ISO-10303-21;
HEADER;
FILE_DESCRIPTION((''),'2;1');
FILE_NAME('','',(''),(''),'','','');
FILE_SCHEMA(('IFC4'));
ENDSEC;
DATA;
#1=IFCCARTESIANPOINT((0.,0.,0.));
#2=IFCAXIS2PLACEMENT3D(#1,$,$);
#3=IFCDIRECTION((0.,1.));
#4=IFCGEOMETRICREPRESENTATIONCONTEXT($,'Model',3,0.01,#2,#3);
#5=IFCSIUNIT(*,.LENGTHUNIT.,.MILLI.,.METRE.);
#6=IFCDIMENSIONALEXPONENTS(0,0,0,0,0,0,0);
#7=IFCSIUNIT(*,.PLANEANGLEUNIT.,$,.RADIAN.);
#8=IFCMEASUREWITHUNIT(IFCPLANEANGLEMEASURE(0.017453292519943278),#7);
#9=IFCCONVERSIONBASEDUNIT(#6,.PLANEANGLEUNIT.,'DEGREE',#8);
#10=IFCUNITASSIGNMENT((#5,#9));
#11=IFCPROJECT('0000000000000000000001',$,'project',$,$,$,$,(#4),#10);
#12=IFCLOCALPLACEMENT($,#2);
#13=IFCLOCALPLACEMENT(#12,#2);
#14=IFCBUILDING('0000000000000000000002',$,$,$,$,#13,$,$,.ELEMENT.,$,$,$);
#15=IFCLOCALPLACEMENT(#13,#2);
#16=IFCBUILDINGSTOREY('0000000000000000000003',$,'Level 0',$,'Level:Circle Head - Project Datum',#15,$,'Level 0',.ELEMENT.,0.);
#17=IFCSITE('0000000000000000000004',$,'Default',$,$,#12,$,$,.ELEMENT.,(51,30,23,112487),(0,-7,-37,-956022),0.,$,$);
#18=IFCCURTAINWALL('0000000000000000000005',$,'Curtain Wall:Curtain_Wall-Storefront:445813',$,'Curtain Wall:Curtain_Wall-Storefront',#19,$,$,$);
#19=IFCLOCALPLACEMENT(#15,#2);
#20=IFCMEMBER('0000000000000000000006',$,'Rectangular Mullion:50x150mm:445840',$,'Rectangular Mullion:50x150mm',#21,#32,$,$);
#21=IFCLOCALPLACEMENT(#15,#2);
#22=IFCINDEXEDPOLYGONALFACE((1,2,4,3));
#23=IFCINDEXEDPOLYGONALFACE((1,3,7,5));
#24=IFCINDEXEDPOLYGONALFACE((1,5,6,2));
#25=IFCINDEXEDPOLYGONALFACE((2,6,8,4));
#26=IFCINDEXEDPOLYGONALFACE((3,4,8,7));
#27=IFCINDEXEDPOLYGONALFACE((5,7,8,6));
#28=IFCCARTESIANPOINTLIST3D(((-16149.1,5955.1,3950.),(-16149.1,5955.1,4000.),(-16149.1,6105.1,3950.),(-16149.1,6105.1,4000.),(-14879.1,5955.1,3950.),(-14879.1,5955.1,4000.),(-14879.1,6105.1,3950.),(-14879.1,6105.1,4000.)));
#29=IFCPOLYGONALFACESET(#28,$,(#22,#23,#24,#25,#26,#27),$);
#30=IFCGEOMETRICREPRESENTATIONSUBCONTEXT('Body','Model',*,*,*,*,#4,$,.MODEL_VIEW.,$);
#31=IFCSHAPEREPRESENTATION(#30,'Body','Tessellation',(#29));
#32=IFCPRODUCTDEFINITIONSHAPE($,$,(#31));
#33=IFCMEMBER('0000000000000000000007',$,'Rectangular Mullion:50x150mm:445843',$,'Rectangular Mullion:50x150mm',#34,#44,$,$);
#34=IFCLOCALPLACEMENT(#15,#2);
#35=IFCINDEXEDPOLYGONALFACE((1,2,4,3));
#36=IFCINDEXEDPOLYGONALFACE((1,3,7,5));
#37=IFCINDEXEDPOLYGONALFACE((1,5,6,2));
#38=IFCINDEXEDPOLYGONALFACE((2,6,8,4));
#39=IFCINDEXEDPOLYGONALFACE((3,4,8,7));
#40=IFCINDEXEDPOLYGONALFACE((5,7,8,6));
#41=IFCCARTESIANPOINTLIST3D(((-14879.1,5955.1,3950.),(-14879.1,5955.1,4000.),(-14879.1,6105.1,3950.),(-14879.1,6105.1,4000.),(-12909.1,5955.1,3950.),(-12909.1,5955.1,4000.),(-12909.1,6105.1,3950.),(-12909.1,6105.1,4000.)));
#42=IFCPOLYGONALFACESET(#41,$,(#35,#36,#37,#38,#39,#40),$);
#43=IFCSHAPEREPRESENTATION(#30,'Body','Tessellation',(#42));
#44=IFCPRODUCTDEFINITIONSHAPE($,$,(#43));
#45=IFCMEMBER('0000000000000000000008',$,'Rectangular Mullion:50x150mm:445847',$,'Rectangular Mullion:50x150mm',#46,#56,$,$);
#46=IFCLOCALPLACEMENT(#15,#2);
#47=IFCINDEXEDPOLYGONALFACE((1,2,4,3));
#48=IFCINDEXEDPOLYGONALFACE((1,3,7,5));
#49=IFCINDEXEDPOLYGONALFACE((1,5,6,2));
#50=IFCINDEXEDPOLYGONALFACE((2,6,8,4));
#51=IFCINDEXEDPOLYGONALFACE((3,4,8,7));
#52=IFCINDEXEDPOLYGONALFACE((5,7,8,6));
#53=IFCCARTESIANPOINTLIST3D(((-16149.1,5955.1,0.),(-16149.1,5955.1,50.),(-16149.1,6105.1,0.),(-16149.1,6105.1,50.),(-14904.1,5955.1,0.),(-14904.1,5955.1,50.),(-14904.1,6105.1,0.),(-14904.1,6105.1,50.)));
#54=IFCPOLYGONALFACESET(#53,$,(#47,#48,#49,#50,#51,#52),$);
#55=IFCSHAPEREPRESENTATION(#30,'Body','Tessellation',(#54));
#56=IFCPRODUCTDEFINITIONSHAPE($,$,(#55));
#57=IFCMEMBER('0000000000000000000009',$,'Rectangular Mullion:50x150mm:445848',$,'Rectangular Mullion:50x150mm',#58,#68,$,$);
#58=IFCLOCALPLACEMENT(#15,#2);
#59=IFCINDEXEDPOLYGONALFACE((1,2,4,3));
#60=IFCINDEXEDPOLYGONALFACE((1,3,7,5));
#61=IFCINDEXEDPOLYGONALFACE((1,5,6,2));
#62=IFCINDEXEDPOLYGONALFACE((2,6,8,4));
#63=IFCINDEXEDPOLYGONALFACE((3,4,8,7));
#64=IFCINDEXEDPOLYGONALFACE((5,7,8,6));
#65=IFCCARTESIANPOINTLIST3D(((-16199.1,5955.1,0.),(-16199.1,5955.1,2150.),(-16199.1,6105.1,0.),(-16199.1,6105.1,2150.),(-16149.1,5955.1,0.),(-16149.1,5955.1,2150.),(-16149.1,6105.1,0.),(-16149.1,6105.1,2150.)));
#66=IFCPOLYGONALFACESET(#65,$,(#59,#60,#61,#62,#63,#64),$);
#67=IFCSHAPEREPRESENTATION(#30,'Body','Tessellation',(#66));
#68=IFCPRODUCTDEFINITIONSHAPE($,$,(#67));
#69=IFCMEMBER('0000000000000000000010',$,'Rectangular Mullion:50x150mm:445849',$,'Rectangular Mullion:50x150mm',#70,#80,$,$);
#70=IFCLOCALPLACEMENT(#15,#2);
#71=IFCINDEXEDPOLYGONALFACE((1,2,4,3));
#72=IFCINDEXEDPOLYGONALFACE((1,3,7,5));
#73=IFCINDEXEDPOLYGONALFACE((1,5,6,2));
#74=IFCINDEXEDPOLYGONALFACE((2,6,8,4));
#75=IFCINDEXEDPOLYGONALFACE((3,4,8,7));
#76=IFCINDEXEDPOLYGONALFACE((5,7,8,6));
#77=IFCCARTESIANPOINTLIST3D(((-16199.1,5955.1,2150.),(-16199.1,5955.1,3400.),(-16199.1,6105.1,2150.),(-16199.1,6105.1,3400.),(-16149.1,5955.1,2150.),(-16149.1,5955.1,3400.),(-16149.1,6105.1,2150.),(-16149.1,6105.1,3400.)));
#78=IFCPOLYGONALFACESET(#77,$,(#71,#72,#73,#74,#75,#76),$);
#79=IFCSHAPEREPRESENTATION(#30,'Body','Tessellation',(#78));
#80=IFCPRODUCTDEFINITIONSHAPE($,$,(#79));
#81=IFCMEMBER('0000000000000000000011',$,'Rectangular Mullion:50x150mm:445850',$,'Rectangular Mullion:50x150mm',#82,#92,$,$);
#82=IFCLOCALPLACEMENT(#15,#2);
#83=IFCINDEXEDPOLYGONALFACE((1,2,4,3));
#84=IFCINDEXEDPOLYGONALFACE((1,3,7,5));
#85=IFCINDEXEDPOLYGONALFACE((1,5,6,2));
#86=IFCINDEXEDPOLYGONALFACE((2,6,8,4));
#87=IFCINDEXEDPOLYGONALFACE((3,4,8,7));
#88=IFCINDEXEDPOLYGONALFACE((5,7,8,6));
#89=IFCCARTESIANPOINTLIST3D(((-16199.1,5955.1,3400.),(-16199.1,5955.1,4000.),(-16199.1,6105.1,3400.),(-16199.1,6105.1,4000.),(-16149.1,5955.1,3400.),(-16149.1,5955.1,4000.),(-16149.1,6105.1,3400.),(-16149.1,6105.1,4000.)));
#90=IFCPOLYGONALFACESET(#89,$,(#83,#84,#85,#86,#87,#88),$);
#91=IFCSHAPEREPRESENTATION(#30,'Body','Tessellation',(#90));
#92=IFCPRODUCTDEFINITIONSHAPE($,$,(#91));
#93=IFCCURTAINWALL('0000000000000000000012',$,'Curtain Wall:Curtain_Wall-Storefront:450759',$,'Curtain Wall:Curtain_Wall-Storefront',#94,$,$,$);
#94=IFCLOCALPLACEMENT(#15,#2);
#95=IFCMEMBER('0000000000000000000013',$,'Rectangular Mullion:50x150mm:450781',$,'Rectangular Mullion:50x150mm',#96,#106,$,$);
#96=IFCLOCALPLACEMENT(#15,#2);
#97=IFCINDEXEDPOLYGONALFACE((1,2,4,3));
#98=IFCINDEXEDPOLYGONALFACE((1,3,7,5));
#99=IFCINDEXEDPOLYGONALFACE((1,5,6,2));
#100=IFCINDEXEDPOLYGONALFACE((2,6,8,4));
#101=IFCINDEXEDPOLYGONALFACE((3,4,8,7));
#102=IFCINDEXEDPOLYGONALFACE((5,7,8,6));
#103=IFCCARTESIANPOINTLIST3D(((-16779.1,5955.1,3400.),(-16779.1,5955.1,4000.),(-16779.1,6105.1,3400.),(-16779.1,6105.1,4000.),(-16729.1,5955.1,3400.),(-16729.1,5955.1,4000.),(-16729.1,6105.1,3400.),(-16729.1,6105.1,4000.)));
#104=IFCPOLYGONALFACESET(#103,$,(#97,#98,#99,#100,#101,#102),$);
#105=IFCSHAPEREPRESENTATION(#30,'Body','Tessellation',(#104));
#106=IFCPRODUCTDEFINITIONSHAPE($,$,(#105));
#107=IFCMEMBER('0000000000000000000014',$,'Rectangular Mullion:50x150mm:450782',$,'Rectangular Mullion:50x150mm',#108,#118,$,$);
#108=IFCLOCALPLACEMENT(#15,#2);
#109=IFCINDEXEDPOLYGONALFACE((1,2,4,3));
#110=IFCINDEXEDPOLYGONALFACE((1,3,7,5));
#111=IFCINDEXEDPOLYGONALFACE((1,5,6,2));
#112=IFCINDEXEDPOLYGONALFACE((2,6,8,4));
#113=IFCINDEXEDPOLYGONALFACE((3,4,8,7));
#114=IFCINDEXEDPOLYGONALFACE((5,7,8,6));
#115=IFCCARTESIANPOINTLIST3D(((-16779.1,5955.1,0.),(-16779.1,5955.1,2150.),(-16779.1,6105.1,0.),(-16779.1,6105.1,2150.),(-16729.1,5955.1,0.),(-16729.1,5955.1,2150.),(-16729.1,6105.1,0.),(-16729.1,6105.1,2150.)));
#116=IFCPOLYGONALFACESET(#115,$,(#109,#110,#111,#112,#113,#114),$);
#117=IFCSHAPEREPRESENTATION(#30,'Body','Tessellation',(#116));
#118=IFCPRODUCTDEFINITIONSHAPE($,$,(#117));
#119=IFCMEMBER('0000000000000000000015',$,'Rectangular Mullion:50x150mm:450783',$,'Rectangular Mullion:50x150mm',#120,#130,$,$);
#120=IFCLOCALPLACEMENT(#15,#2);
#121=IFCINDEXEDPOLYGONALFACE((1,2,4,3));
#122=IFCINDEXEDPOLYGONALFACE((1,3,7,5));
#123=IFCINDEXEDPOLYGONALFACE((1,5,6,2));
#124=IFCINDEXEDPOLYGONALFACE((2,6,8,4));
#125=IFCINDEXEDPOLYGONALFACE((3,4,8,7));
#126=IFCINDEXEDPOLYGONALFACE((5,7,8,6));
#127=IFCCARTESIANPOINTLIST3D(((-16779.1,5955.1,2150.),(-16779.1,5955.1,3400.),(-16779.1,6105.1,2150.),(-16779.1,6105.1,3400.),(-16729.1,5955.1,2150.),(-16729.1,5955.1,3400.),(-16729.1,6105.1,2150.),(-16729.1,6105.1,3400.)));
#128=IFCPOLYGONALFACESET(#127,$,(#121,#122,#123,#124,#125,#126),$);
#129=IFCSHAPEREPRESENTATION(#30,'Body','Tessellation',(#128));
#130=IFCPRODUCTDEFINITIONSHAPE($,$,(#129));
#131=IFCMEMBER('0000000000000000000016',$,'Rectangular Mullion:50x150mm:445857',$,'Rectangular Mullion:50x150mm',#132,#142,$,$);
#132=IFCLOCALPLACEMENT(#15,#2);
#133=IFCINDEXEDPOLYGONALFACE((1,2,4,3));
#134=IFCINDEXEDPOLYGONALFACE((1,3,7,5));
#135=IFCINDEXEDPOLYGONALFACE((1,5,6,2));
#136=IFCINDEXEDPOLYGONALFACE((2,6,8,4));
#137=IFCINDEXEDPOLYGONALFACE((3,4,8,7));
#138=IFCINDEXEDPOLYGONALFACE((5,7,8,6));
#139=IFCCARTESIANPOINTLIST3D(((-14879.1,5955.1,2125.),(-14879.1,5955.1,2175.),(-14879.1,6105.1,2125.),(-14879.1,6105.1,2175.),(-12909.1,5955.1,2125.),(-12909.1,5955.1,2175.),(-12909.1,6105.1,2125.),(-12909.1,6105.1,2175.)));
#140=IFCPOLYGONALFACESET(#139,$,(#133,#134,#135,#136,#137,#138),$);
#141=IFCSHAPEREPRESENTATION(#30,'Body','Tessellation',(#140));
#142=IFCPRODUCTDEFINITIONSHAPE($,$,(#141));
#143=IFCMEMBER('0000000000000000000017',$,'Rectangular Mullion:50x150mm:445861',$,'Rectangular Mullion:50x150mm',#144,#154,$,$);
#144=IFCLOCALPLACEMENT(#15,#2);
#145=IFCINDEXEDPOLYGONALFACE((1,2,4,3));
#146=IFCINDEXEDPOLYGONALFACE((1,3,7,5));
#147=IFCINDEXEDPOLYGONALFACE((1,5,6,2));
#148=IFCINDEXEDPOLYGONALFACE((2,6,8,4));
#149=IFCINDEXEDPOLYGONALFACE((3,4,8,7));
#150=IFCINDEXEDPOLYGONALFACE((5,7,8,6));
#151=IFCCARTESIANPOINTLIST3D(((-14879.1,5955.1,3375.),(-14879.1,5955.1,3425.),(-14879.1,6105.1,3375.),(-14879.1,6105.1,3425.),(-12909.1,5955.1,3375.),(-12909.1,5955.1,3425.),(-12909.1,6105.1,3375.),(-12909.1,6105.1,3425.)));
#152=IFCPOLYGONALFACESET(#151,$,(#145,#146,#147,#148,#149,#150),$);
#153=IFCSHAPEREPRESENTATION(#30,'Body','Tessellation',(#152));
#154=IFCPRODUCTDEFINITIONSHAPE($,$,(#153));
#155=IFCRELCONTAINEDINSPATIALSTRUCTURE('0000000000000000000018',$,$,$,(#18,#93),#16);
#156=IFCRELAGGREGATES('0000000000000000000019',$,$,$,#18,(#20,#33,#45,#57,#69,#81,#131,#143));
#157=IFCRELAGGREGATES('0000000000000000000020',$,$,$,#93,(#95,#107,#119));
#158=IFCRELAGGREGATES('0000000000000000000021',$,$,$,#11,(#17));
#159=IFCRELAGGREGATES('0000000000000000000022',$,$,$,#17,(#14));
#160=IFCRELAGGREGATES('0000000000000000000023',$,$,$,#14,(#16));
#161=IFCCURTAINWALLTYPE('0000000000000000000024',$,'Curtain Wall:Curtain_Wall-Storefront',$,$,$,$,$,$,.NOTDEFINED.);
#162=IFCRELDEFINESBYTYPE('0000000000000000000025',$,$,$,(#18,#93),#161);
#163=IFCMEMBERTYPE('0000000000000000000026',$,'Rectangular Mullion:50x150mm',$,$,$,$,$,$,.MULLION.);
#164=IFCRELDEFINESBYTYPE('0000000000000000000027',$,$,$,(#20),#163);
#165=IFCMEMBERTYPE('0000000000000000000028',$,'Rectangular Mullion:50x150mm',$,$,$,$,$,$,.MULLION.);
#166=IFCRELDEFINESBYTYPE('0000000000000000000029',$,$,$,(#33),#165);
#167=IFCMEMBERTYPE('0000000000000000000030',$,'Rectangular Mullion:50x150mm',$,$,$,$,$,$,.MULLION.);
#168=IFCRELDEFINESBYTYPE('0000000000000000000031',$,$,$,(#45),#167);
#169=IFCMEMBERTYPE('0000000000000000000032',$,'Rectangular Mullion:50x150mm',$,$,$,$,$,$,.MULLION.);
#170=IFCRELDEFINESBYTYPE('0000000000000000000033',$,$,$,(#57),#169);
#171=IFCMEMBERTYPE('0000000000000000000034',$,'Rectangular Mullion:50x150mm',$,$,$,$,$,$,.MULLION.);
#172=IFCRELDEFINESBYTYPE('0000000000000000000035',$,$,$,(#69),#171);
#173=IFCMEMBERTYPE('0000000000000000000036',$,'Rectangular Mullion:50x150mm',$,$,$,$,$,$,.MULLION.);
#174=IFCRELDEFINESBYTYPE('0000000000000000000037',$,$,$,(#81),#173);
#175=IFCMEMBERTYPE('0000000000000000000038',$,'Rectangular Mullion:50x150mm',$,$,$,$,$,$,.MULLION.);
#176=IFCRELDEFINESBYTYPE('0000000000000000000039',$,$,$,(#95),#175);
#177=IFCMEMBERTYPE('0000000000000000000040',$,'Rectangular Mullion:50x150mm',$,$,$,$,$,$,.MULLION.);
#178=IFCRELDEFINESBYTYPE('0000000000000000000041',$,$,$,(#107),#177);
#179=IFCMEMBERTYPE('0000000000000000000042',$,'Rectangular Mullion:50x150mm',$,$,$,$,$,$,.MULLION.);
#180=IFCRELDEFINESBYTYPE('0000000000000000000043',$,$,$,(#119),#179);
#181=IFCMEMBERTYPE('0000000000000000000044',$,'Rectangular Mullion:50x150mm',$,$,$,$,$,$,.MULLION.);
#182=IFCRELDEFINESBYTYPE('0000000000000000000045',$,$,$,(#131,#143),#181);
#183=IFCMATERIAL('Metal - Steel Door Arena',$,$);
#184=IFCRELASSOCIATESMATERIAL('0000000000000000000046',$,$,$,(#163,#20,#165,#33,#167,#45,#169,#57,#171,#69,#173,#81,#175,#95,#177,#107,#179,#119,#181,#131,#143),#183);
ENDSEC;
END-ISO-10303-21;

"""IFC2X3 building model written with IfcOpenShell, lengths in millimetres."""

from ifc_helpers import new_model, entity, si_unit, converted_unit, direction, frame, origin, origin_2d_with_axis, place, context, subcontext, project, spatial, rectangle, extrude, source, transform, mapped, material, type_object, type_shapes, element, aggregate, save


model = new_model("IFC2X3")

# Units and contexts
model_context = context("Model", 3, precision=0.01, world=origin(), true_north=direction((0.0, 1.0)))
body_context = subcontext(model_context, "Body", "Model", "MODEL_VIEW")
ifc_project = project(units=[si_unit("LENGTHUNIT", "METRE", prefix="MILLI"), converted_unit("PLANEANGLEUNIT", "DEGREE", entity("IfcPlaneAngleMeasure", 0.017453292519943278), si_unit("PLANEANGLEUNIT", "RADIAN"), dimensions=[0, 0, 0, 0, 0, 0, 0])], contexts=[model_context])

# Site, building, storey
site_placement = place(None, origin())
site = spatial("IfcSite", under=ifc_project, at=site_placement, Name="Default", CompositionType="ELEMENT", RefLatitude=(51, 30, 23, 112487), RefLongitude=(0, -7, -37, -956022), RefElevation=0.0)
building_placement = place(site_placement, origin())
building = spatial("IfcBuilding", under=site, at=building_placement, CompositionType="ELEMENT")
storey_placement = place(building_placement, origin())
storey = spatial("IfcBuildingStorey", under=building, at=storey_placement, Name="Level 0", ObjectType="Level:Circle Head - Project Datum", LongName="Level 0", CompositionType="ELEMENT", Elevation=0.0)

# Curtain walls, members
curtain_wall_type = type_object("IfcCurtainWallType", Name="Curtain Wall:Curtain_Wall-Storefront", PredefinedType="NOTDEFINED")
curtain_wall_1_placement = place(storey_placement, origin())
curtain_wall_1 = element("IfcCurtainWall", 1, at=curtain_wall_1_placement, inside=storey, type_object=curtain_wall_type, Name="Curtain Wall:Curtain_Wall-Storefront:445813", ObjectType="Curtain Wall:Curtain_Wall-Storefront")
ifc_material_1 = material(Name="Metal - Steel Door Arena")
member_type_1 = type_object("IfcMemberType", Name="Rectangular Mullion:50x150mm", PredefinedType="MULLION", material=ifc_material_1)
shared_shape_1 = source(origin(), body_context, "Body", "SweptSolid", [
    extrude(rectangle(XDim=50.0, YDim=150.0, at=origin_2d_with_axis()), frame((-25.0, 0.0, -1270.0), z_axis=(0.0, 0.0, 1.0), x_axis=(-1.0, 0.0, 0.0)), (0.0, 0.0, 1.0), 1270.0),
])
type_shapes(member_type_1, [shared_shape_1])
member_1_placement = place(curtain_wall_1_placement, frame((-16149.1, 6030.1, 4000.0), z_axis=(-1.0, 0.0, 0.0), x_axis=(0.0, 0.0, 1.0)))
member_1 = element("IfcMember", 2, at=member_1_placement, type_object=member_type_1, material=ifc_material_1, Name="Rectangular Mullion:50x150mm:445840", ObjectType="Rectangular Mullion:50x150mm", context=body_context, shape_type="MappedRepresentation", body=[
    mapped(shared_shape_1, transform((0.0, 0.0, 0.0), scale=1.0)),
])
member_type_2 = type_object("IfcMemberType", Name="Rectangular Mullion:50x150mm", PredefinedType="MULLION", material=ifc_material_1)
shared_shape_2 = source(origin(), body_context, "Body", "SweptSolid", [
    extrude(rectangle(XDim=50.0, YDim=150.0, at=origin_2d_with_axis()), frame((-25.0, 0.0, -1970.0), z_axis=(0.0, 0.0, 1.0), x_axis=(-1.0, 0.0, 0.0)), (0.0, 0.0, 1.0), 1970.0),
])
type_shapes(member_type_2, [shared_shape_2])
member_2_placement = place(curtain_wall_1_placement, frame((-14879.1, 6030.1, 4000.0), z_axis=(-1.0, 0.0, 0.0), x_axis=(0.0, 0.0, 1.0)))
member_2 = element("IfcMember", 3, at=member_2_placement, type_object=member_type_2, material=ifc_material_1, Name="Rectangular Mullion:50x150mm:445843", ObjectType="Rectangular Mullion:50x150mm", context=body_context, shape_type="MappedRepresentation", body=[
    mapped(shared_shape_2, transform((0.0, 0.0, 0.0), scale=1.0)),
])
member_type_3 = type_object("IfcMemberType", Name="Rectangular Mullion:50x150mm", PredefinedType="MULLION", material=ifc_material_1)
shared_shape_3 = source(origin(), body_context, "Body", "SweptSolid", [
    extrude(rectangle(XDim=50.0, YDim=150.0, at=origin_2d_with_axis()), frame((-25.0, 0.0, -1245.0), z_axis=(0.0, 0.0, 1.0), x_axis=(-1.0, 0.0, 0.0)), (0.0, 0.0, 1.0), 1245.0),
])
type_shapes(member_type_3, [shared_shape_3])
member_3_placement = place(curtain_wall_1_placement, frame((-14904.1, 6030.1, 0.0), z_axis=(1.0, 0.0, 0.0), x_axis=(0.0, 0.0, -1.0)))
member_3 = element("IfcMember", 4, at=member_3_placement, type_object=member_type_3, material=ifc_material_1, Name="Rectangular Mullion:50x150mm:445847", ObjectType="Rectangular Mullion:50x150mm", context=body_context, shape_type="MappedRepresentation", body=[
    mapped(shared_shape_3, transform((0.0, 0.0, 0.0), scale=1.0)),
])
member_type_4 = type_object("IfcMemberType", Name="Rectangular Mullion:50x150mm", PredefinedType="MULLION", material=ifc_material_1)
shared_shape_4 = source(origin(), body_context, "Body", "SweptSolid", [
    extrude(rectangle(XDim=50.0, YDim=150.0, at=origin_2d_with_axis()), frame((-25.0, 0.0, -2150.0), z_axis=(0.0, 0.0, 1.0), x_axis=(-1.0, 0.0, 0.0)), (0.0, 0.0, 1.0), 2150.0),
])
type_shapes(member_type_4, [shared_shape_4])
member_4_placement = place(curtain_wall_1_placement, frame((-16199.1, 6030.1, 0.0), z_axis=(0.0, 0.0, -1.0), x_axis=(-1.0, 0.0, 0.0)))
member_4 = element("IfcMember", 5, at=member_4_placement, type_object=member_type_4, material=ifc_material_1, Name="Rectangular Mullion:50x150mm:445848", ObjectType="Rectangular Mullion:50x150mm", context=body_context, shape_type="MappedRepresentation", body=[
    mapped(shared_shape_4, transform((0.0, 0.0, 0.0), scale=1.0)),
])
member_type_5 = type_object("IfcMemberType", Name="Rectangular Mullion:50x150mm", PredefinedType="MULLION", material=ifc_material_1)
shared_shape_5 = source(origin(), body_context, "Body", "SweptSolid", [
    extrude(rectangle(XDim=50.0, YDim=150.0, at=origin_2d_with_axis()), frame((-25.0, 0.0, -1250.0), z_axis=(0.0, 0.0, 1.0), x_axis=(-1.0, 0.0, 0.0)), (0.0, 0.0, 1.0), 1250.0),
])
type_shapes(member_type_5, [shared_shape_5])
member_5_placement = place(curtain_wall_1_placement, frame((-16199.1, 6030.1, 2150.0), z_axis=(0.0, 0.0, -1.0), x_axis=(-1.0, 0.0, 0.0)))
member_5 = element("IfcMember", 6, at=member_5_placement, type_object=member_type_5, material=ifc_material_1, Name="Rectangular Mullion:50x150mm:445849", ObjectType="Rectangular Mullion:50x150mm", context=body_context, shape_type="MappedRepresentation", body=[
    mapped(shared_shape_5, transform((0.0, 0.0, 0.0), scale=1.0)),
])
member_type_6 = type_object("IfcMemberType", Name="Rectangular Mullion:50x150mm", PredefinedType="MULLION", material=ifc_material_1)
shared_shape_6 = source(origin(), body_context, "Body", "SweptSolid", [
    extrude(rectangle(XDim=50.0, YDim=150.0, at=origin_2d_with_axis()), frame((-25.0, 0.0, -600.0), z_axis=(0.0, 0.0, 1.0), x_axis=(-1.0, 0.0, 0.0)), (0.0, 0.0, 1.0), 600.0),
])
type_shapes(member_type_6, [shared_shape_6])
member_6_placement = place(curtain_wall_1_placement, frame((-16199.1, 6030.1, 3400.0), z_axis=(0.0, 0.0, -1.0), x_axis=(-1.0, 0.0, 0.0)))
member_6 = element("IfcMember", 7, at=member_6_placement, type_object=member_type_6, material=ifc_material_1, Name="Rectangular Mullion:50x150mm:445850", ObjectType="Rectangular Mullion:50x150mm", context=body_context, shape_type="MappedRepresentation", body=[
    mapped(shared_shape_6, transform((0.0, 0.0, 0.0), scale=1.0)),
])
curtain_wall_2_placement = place(storey_placement, origin())
curtain_wall_2 = element("IfcCurtainWall", 8, at=curtain_wall_2_placement, inside=storey, type_object=curtain_wall_type, Name="Curtain Wall:Curtain_Wall-Storefront:450759", ObjectType="Curtain Wall:Curtain_Wall-Storefront")
member_type_7 = type_object("IfcMemberType", Name="Rectangular Mullion:50x150mm", PredefinedType="MULLION", material=ifc_material_1)
shared_shape_7 = source(origin(), body_context, "Body", "SweptSolid", [
    extrude(rectangle(XDim=50.0, YDim=150.0, at=origin_2d_with_axis()), frame((-25.0, 0.0, -600.0), z_axis=(0.0, 0.0, 1.0), x_axis=(-1.0, 0.0, 0.0)), (0.0, 0.0, 1.0), 600.0),
])
type_shapes(member_type_7, [shared_shape_7])
member_7_placement = place(curtain_wall_2_placement, frame((-16729.1, 6030.1, 4000.0)))
member_7 = element("IfcMember", 9, at=member_7_placement, type_object=member_type_7, material=ifc_material_1, Name="Rectangular Mullion:50x150mm:450781", ObjectType="Rectangular Mullion:50x150mm", context=body_context, shape_type="MappedRepresentation", body=[
    mapped(shared_shape_7, transform((0.0, 0.0, 0.0), scale=1.0)),
])
member_type_8 = type_object("IfcMemberType", Name="Rectangular Mullion:50x150mm", PredefinedType="MULLION", material=ifc_material_1)
shared_shape_8 = source(origin(), body_context, "Body", "SweptSolid", [
    extrude(rectangle(XDim=50.0, YDim=150.0, at=origin_2d_with_axis()), frame((-25.0, 0.0, -2150.0), z_axis=(0.0, 0.0, 1.0), x_axis=(-1.0, 0.0, 0.0)), (0.0, 0.0, 1.0), 2150.0),
])
type_shapes(member_type_8, [shared_shape_8])
member_8_placement = place(curtain_wall_2_placement, frame((-16729.1, 6030.1, 2150.0)))
member_8 = element("IfcMember", 10, at=member_8_placement, type_object=member_type_8, material=ifc_material_1, Name="Rectangular Mullion:50x150mm:450782", ObjectType="Rectangular Mullion:50x150mm", context=body_context, shape_type="MappedRepresentation", body=[
    mapped(shared_shape_8, transform((0.0, 0.0, 0.0), scale=1.0)),
])
member_type_9 = type_object("IfcMemberType", Name="Rectangular Mullion:50x150mm", PredefinedType="MULLION", material=ifc_material_1)
shared_shape_9 = source(origin(), body_context, "Body", "SweptSolid", [
    extrude(rectangle(XDim=50.0, YDim=150.0, at=origin_2d_with_axis()), frame((-25.0, 0.0, -1250.0), z_axis=(0.0, 0.0, 1.0), x_axis=(-1.0, 0.0, 0.0)), (0.0, 0.0, 1.0), 1250.0),
])
type_shapes(member_type_9, [shared_shape_9])
member_9_placement = place(curtain_wall_2_placement, frame((-16729.1, 6030.1, 3400.0)))
member_9 = element("IfcMember", 11, at=member_9_placement, type_object=member_type_9, material=ifc_material_1, Name="Rectangular Mullion:50x150mm:450783", ObjectType="Rectangular Mullion:50x150mm", context=body_context, shape_type="MappedRepresentation", body=[
    mapped(shared_shape_9, transform((0.0, 0.0, 0.0), scale=1.0)),
])

# Members
member_type_10 = type_object("IfcMemberType", Name="Rectangular Mullion:50x150mm", PredefinedType="MULLION", material=ifc_material_1)
shared_shape_10 = source(origin(), body_context, "Body", "SweptSolid", [
    extrude(rectangle(XDim=50.0, YDim=150.0, at=origin_2d_with_axis()), frame((0.0, 0.0, -1970.0), z_axis=(0.0, 0.0, 1.0), x_axis=(-1.0, 0.0, 0.0)), (0.0, 0.0, 1.0), 1970.0),
])
type_shapes(member_type_10, [shared_shape_10])
member_10_placement = place(curtain_wall_1_placement, frame((-14879.1, 6030.1, 2150.0), z_axis=(-1.0, 0.0, 0.0), x_axis=(0.0, 0.0, 1.0)))
member_10 = element("IfcMember", 12, at=member_10_placement, type_object=member_type_10, material=ifc_material_1, Name="Rectangular Mullion:50x150mm:445857", ObjectType="Rectangular Mullion:50x150mm", context=body_context, shape_type="MappedRepresentation", body=[
    mapped(shared_shape_10, transform((0.0, 0.0, 0.0), scale=1.0)),
])
member_11_placement = place(curtain_wall_1_placement, frame((-14879.1, 6030.1, 3400.0), z_axis=(-1.0, 0.0, 0.0), x_axis=(0.0, 0.0, 1.0)))
member_11 = element("IfcMember", 13, at=member_11_placement, type_object=member_type_10, material=ifc_material_1, Name="Rectangular Mullion:50x150mm:445861", ObjectType="Rectangular Mullion:50x150mm", context=body_context, shape_type="MappedRepresentation", body=[
    mapped(shared_shape_10, transform((0.0, 0.0, 0.0), scale=1.0)),
])

aggregate(curtain_wall_1, [member_1, member_2, member_3, member_4, member_5, member_6, member_10, member_11])
aggregate(curtain_wall_2, [member_7, member_8, member_9])

save(model, "model.ifc")
